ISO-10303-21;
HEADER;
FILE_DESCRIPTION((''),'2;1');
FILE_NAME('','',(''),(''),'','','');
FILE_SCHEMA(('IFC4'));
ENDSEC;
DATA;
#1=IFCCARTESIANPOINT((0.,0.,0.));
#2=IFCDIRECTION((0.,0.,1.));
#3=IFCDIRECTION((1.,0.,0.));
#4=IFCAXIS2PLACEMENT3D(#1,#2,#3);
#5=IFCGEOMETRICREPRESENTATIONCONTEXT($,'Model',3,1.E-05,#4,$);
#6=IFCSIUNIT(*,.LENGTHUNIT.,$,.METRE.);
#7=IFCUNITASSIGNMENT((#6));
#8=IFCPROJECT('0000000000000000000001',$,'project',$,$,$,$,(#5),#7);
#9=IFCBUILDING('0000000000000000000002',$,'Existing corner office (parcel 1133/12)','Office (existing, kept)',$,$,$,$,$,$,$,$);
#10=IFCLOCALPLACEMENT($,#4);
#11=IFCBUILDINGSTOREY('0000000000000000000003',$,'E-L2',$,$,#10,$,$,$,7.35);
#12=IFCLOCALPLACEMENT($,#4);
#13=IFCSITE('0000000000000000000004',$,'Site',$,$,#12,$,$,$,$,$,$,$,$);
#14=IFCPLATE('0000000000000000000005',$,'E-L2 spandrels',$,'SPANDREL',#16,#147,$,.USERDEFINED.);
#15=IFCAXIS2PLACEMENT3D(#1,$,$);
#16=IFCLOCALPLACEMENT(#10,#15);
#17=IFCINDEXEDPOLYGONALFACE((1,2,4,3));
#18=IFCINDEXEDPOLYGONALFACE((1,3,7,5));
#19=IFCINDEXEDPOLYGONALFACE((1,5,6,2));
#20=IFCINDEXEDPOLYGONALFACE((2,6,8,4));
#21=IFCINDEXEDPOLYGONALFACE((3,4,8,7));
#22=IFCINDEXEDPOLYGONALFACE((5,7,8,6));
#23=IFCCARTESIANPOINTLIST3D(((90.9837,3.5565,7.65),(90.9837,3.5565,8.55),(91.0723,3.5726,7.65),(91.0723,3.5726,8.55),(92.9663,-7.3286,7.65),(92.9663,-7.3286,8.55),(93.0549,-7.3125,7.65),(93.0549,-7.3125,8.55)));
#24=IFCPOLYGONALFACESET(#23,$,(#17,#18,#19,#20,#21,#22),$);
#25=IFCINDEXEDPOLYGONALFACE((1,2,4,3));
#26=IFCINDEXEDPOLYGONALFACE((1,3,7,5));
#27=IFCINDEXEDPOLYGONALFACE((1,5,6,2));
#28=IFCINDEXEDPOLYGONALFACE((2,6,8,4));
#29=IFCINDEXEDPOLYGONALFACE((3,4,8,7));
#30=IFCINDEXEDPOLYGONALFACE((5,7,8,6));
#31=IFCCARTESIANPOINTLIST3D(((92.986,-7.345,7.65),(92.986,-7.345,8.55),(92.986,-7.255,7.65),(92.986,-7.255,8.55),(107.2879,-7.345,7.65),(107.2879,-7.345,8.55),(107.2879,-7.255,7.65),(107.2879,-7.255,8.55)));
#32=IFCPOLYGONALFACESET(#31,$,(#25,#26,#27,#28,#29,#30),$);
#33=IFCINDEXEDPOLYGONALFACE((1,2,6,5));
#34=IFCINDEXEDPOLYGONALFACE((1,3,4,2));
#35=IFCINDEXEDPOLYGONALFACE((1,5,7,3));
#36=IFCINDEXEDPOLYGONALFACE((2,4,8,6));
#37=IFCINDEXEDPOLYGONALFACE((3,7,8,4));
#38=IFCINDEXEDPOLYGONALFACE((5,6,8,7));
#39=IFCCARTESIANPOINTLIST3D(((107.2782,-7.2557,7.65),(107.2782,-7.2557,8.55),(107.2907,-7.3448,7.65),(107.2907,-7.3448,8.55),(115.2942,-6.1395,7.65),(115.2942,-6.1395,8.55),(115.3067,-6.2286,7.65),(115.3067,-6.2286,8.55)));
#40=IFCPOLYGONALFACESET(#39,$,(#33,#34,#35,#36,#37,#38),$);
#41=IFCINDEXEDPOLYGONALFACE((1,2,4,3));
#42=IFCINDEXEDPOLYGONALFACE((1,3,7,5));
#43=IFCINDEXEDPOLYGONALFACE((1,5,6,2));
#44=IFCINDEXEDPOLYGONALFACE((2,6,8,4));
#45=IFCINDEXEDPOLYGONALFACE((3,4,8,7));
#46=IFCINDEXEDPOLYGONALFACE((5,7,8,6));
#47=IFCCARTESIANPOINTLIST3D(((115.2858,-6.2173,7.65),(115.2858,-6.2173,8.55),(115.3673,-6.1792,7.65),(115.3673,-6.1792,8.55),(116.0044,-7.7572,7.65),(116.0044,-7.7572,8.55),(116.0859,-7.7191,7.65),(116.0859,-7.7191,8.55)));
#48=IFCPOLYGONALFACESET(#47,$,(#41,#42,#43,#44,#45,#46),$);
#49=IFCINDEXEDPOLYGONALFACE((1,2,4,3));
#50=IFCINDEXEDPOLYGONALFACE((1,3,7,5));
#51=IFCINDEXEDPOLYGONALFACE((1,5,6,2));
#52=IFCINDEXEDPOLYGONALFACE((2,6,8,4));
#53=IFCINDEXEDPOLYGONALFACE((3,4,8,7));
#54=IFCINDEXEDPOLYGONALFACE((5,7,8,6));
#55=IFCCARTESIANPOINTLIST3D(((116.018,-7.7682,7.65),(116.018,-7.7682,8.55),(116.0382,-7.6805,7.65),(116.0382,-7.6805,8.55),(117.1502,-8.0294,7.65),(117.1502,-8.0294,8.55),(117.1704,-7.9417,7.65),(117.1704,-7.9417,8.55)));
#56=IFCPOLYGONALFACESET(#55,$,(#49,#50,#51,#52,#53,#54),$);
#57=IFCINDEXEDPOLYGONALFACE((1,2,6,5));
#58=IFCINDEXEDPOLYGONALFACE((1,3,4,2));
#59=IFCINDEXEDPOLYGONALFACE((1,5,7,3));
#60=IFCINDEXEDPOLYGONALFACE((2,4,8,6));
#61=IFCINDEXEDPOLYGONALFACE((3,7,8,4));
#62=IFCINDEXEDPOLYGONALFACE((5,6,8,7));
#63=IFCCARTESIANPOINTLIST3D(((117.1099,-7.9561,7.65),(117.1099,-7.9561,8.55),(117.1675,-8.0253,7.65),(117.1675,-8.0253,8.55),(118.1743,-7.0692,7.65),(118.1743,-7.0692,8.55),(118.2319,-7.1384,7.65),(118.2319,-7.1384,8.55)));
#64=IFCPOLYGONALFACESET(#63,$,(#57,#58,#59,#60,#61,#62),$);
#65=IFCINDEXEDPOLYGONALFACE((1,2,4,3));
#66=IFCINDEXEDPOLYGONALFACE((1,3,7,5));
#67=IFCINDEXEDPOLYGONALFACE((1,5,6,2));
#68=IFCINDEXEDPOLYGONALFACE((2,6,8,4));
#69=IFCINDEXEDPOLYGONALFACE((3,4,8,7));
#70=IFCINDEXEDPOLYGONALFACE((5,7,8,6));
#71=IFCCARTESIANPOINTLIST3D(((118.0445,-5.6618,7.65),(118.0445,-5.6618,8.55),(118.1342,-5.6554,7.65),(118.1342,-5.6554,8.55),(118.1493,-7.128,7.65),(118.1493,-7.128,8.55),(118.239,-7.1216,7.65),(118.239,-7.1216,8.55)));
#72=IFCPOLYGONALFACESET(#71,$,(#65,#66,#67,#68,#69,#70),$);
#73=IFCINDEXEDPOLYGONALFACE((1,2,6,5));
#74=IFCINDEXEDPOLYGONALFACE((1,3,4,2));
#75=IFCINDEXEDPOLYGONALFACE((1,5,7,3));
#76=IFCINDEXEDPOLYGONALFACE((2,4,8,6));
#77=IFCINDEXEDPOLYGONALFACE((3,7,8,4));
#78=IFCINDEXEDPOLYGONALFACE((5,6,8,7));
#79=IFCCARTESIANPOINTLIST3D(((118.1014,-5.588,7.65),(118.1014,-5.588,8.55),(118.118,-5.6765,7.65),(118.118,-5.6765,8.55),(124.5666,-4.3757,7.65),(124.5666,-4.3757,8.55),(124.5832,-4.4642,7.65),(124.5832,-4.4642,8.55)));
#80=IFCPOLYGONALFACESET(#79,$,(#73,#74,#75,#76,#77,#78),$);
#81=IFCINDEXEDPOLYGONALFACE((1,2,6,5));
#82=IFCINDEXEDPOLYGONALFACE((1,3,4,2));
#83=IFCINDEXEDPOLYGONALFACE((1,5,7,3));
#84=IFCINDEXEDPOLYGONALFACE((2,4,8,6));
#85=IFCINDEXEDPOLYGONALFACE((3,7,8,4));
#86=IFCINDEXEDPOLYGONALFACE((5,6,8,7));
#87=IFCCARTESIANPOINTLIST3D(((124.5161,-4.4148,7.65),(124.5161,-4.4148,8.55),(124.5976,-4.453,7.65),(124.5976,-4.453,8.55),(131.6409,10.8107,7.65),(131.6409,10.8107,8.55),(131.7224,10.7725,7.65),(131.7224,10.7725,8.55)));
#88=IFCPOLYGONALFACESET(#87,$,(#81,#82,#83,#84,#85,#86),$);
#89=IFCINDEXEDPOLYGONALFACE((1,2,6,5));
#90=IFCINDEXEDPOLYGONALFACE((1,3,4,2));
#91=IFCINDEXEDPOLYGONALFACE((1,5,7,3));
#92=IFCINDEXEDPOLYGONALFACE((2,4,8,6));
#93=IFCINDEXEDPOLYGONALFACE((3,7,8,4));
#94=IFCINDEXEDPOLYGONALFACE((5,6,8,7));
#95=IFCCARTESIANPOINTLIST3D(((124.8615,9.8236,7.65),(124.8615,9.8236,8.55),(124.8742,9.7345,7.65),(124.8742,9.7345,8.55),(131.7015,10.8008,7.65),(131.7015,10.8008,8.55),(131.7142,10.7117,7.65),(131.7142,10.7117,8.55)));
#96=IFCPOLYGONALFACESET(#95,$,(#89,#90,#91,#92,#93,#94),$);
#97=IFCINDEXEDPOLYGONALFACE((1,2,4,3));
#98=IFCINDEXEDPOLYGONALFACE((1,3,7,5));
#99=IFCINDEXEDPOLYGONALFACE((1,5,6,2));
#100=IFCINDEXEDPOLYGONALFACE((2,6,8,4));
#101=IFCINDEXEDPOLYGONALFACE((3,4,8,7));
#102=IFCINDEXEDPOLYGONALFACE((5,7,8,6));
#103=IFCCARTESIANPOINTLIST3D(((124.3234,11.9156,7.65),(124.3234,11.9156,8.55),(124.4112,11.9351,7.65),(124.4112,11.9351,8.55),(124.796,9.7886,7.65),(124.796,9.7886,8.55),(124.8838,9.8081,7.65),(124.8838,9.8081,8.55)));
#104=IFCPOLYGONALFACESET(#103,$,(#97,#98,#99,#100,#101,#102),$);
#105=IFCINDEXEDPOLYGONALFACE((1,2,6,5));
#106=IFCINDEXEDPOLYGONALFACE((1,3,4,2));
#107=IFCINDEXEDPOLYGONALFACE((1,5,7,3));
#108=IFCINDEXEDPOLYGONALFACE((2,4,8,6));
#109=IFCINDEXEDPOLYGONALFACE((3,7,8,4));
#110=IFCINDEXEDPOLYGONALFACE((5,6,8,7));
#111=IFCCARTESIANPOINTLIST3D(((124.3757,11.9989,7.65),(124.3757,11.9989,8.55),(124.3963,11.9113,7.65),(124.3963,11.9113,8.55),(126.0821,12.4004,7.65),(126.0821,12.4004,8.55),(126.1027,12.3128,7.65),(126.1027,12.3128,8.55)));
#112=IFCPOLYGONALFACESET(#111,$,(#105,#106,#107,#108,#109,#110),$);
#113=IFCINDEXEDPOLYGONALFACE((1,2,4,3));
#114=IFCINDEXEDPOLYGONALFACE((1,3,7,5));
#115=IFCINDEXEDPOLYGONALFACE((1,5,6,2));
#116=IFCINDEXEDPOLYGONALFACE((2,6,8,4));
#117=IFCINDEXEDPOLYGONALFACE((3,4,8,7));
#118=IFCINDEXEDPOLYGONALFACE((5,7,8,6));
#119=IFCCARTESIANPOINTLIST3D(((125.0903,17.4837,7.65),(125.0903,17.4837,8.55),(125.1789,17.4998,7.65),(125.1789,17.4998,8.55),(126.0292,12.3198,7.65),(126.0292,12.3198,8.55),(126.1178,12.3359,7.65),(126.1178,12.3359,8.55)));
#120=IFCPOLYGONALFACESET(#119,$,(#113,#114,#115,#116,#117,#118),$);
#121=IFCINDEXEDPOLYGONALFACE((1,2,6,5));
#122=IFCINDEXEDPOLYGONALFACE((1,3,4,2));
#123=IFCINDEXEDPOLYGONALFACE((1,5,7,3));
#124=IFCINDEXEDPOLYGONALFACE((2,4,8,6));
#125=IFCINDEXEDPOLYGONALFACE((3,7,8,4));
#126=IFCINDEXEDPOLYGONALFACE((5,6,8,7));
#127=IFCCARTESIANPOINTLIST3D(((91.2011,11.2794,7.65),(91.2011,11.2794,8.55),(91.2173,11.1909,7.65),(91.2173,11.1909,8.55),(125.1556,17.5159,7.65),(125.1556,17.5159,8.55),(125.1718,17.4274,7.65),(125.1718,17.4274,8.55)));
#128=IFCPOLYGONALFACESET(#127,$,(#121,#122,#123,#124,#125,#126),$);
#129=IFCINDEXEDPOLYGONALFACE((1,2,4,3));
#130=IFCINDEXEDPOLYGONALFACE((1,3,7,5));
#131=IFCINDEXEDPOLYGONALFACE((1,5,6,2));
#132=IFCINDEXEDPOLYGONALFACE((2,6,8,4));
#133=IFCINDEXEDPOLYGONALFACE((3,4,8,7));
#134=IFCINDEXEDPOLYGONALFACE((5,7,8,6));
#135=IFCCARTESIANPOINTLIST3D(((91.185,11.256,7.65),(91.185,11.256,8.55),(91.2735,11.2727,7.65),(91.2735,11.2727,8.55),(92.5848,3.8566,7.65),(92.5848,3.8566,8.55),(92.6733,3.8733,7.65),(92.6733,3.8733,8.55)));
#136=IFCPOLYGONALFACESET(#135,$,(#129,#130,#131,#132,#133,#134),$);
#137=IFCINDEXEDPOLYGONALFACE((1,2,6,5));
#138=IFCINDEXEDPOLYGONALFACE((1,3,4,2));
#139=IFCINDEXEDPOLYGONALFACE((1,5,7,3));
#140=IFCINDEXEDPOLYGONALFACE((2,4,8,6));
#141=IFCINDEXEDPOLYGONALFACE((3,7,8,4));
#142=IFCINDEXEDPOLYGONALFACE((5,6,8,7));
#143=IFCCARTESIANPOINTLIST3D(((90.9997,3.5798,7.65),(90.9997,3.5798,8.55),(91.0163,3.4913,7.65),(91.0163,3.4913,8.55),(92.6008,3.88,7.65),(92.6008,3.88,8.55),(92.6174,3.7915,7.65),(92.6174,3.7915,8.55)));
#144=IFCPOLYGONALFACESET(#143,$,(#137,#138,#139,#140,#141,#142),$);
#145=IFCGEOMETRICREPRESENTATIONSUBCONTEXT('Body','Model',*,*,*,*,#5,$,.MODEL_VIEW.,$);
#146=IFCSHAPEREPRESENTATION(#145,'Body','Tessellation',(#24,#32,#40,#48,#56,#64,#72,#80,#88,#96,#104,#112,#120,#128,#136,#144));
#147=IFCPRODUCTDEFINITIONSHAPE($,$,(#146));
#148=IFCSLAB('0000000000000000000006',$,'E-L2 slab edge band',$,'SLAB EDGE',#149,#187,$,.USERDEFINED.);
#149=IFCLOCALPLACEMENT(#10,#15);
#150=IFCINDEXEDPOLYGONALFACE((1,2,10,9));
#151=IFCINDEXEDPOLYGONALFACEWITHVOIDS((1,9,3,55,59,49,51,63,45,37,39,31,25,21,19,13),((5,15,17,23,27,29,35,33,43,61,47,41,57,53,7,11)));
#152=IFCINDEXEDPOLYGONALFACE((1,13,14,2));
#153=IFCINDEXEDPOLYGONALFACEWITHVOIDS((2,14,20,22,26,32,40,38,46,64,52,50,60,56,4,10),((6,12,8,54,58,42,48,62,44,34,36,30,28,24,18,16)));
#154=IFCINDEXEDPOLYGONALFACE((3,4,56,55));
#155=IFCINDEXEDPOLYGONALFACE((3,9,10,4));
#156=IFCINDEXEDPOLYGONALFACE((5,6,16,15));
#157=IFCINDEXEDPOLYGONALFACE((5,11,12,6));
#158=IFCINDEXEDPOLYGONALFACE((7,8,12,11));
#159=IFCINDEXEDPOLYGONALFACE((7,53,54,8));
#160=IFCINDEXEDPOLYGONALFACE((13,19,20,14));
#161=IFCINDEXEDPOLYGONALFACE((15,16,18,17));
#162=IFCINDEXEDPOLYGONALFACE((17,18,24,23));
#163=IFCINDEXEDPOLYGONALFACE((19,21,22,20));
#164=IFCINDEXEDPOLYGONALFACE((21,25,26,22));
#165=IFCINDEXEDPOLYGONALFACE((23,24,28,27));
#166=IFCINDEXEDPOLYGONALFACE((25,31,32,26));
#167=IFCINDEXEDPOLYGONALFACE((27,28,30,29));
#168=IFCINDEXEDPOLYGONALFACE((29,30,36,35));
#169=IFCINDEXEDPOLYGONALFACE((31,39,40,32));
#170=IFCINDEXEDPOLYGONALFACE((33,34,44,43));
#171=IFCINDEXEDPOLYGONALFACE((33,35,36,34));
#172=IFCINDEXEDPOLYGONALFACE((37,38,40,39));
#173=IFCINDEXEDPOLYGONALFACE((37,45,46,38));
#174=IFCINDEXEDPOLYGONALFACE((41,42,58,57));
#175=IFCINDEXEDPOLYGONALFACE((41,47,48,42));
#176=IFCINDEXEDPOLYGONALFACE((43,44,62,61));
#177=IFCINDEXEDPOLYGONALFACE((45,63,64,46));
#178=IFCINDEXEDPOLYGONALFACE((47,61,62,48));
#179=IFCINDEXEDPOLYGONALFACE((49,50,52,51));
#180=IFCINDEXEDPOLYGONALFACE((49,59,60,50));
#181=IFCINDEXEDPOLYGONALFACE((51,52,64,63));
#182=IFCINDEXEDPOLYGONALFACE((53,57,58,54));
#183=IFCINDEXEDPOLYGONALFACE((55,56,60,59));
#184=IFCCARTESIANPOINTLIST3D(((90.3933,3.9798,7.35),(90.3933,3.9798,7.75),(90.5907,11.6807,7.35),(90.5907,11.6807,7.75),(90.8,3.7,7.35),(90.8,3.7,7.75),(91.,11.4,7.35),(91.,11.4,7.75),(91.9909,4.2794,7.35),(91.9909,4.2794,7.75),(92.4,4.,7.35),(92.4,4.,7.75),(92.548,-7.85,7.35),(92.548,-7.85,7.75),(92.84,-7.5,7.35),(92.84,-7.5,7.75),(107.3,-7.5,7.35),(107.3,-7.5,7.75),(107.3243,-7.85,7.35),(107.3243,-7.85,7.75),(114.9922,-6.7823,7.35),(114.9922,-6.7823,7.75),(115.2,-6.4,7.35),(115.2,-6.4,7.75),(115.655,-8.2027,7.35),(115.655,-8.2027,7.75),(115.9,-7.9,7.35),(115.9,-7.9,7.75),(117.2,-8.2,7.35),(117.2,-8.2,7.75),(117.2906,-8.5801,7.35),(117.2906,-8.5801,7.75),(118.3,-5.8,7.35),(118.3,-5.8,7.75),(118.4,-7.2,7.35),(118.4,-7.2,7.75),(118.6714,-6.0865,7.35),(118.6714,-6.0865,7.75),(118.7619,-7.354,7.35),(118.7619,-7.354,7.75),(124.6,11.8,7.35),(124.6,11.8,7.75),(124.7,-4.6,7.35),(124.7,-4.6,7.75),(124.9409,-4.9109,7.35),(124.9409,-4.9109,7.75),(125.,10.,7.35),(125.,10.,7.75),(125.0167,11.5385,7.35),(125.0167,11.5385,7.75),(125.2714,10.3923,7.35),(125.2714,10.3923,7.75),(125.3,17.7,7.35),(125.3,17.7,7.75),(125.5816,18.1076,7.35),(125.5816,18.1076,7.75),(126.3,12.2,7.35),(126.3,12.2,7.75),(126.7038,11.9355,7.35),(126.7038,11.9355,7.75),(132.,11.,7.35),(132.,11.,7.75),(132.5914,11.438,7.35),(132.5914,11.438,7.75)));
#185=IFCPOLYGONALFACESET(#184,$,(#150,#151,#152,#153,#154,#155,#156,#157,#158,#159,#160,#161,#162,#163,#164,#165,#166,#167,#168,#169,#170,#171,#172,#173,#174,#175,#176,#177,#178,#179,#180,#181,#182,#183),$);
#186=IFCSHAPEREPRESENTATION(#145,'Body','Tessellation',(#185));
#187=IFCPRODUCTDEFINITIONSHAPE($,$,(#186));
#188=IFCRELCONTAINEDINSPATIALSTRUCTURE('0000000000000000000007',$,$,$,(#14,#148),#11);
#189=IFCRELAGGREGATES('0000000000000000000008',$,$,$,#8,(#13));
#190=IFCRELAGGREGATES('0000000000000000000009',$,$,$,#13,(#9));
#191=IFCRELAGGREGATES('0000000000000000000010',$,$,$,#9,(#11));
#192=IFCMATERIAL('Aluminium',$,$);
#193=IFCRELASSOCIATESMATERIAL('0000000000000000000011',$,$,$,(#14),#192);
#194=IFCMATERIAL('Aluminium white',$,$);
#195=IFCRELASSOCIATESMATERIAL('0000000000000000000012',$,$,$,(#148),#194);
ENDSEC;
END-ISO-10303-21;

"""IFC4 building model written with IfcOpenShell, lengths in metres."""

from ifc_helpers import new_model, si_unit, frame, origin_with_axes, place, context, subcontext, project, spatial, polyline, outline, extrude, material, element, save


model = new_model("IFC4")

# Units and contexts
model_context = context("Model", 3, precision=1e-05, world=origin_with_axes())
body_context = subcontext(model_context, "Body", "Model", "MODEL_VIEW")
ifc_project = project(units=[si_unit("LENGTHUNIT", "METRE")], contexts=[model_context])

# Site, building, storey
site_placement = place(None, origin_with_axes())
site = spatial("IfcSite", under=ifc_project, at=site_placement, Name="Site")
building = spatial("IfcBuilding", under=site, Name="Existing corner office (parcel 1133/12)", Description="Office (existing, kept)")
storey_placement = place(None, origin_with_axes())
storey = spatial("IfcBuildingStorey", under=building, at=storey_placement, Name="E-L2", Elevation=7.35)

# Shared definitions
ifc_material_1 = material(Name="Aluminium")
ifc_material_2 = material(Name="Aluminium white")

# Plate
plate_placement = place(storey_placement, origin_with_axes())
element("IfcPlate", 1, at=plate_placement, inside=storey, material=ifc_material_1, Name="E-L2 spandrels", ObjectType="SPANDREL", PredefinedType="USERDEFINED", context=body_context, shape_type="SweptSolid", body=[
    extrude(outline(polyline([(90.9837, 3.5565), (92.9663, -7.3286), (93.0549, -7.3125), (91.0723, 3.5726), (90.9837, 3.5565)])), frame((0.0, 0.0, 7.65), z_axis=(0.0, 0.0, 1.0), x_axis=(1.0, 0.0, 0.0)), (0.0, 0.0, 1.0), 0.9),
    extrude(outline(polyline([(92.986, -7.345), (107.2879, -7.345), (107.2879, -7.255), (92.986, -7.255), (92.986, -7.345)])), frame((0.0, 0.0, 7.65), z_axis=(0.0, 0.0, 1.0), x_axis=(1.0, 0.0, 0.0)), (0.0, 0.0, 1.0), 0.9),
    extrude(outline(polyline([(107.2907, -7.3448), (115.3067, -6.2286), (115.2942, -6.1395), (107.2782, -7.2557), (107.2907, -7.3448)])), frame((0.0, 0.0, 7.65), z_axis=(0.0, 0.0, 1.0), x_axis=(1.0, 0.0, 0.0)), (0.0, 0.0, 1.0), 0.9),
    extrude(outline(polyline([(115.2858, -6.2173), (116.0044, -7.7572), (116.0859, -7.7191), (115.3673, -6.1792), (115.2858, -6.2173)])), frame((0.0, 0.0, 7.65), z_axis=(0.0, 0.0, 1.0), x_axis=(1.0, 0.0, 0.0)), (0.0, 0.0, 1.0), 0.9),
    extrude(outline(polyline([(116.018, -7.7682), (117.1502, -8.0294), (117.1704, -7.9417), (116.0382, -7.6805), (116.018, -7.7682)])), frame((0.0, 0.0, 7.65), z_axis=(0.0, 0.0, 1.0), x_axis=(1.0, 0.0, 0.0)), (0.0, 0.0, 1.0), 0.9),
    extrude(outline(polyline([(117.1675, -8.0253), (118.2319, -7.1384), (118.1743, -7.0692), (117.1099, -7.9561), (117.1675, -8.0253)])), frame((0.0, 0.0, 7.65), z_axis=(0.0, 0.0, 1.0), x_axis=(1.0, 0.0, 0.0)), (0.0, 0.0, 1.0), 0.9),
    extrude(outline(polyline([(118.239, -7.1216), (118.1342, -5.6554), (118.0445, -5.6618), (118.1493, -7.128), (118.239, -7.1216)])), frame((0.0, 0.0, 7.65), z_axis=(0.0, 0.0, 1.0), x_axis=(1.0, 0.0, 0.0)), (0.0, 0.0, 1.0), 0.9),
    extrude(outline(polyline([(118.118, -5.6765), (124.5832, -4.4642), (124.5666, -4.3757), (118.1014, -5.588), (118.118, -5.6765)])), frame((0.0, 0.0, 7.65), z_axis=(0.0, 0.0, 1.0), x_axis=(1.0, 0.0, 0.0)), (0.0, 0.0, 1.0), 0.9),
    extrude(outline(polyline([(124.5976, -4.453), (131.7224, 10.7725), (131.6409, 10.8107), (124.5161, -4.4148), (124.5976, -4.453)])), frame((0.0, 0.0, 7.65), z_axis=(0.0, 0.0, 1.0), x_axis=(1.0, 0.0, 0.0)), (0.0, 0.0, 1.0), 0.9),
    extrude(outline(polyline([(131.7015, 10.8008), (124.8615, 9.8236), (124.8742, 9.7345), (131.7142, 10.7117), (131.7015, 10.8008)])), frame((0.0, 0.0, 7.65), z_axis=(0.0, 0.0, 1.0), x_axis=(1.0, 0.0, 0.0)), (0.0, 0.0, 1.0), 0.9),
    extrude(outline(polyline([(124.8838, 9.8081), (124.4112, 11.9351), (124.3234, 11.9156), (124.796, 9.7886), (124.8838, 9.8081)])), frame((0.0, 0.0, 7.65), z_axis=(0.0, 0.0, 1.0), x_axis=(1.0, 0.0, 0.0)), (0.0, 0.0, 1.0), 0.9),
    extrude(outline(polyline([(124.3963, 11.9113), (126.1027, 12.3128), (126.0821, 12.4004), (124.3757, 11.9989), (124.3963, 11.9113)])), frame((0.0, 0.0, 7.65), z_axis=(0.0, 0.0, 1.0), x_axis=(1.0, 0.0, 0.0)), (0.0, 0.0, 1.0), 0.9),
    extrude(outline(polyline([(126.1178, 12.3359), (125.1789, 17.4998), (125.0903, 17.4837), (126.0292, 12.3198), (126.1178, 12.3359)])), frame((0.0, 0.0, 7.65), z_axis=(0.0, 0.0, 1.0), x_axis=(1.0, 0.0, 0.0)), (0.0, 0.0, 1.0), 0.9),
    extrude(outline(polyline([(125.1556, 17.5159), (91.2011, 11.2794), (91.2173, 11.1909), (125.1718, 17.4274), (125.1556, 17.5159)])), frame((0.0, 0.0, 7.65), z_axis=(0.0, 0.0, 1.0), x_axis=(1.0, 0.0, 0.0)), (0.0, 0.0, 1.0), 0.9),
    extrude(outline(polyline([(91.185, 11.256), (92.5848, 3.8566), (92.6733, 3.8733), (91.2735, 11.2727), (91.185, 11.256)])), frame((0.0, 0.0, 7.65), z_axis=(0.0, 0.0, 1.0), x_axis=(1.0, 0.0, 0.0)), (0.0, 0.0, 1.0), 0.9),
    extrude(outline(polyline([(92.6008, 3.88), (90.9997, 3.5798), (91.0163, 3.4913), (92.6174, 3.7915), (92.6008, 3.88)])), frame((0.0, 0.0, 7.65), z_axis=(0.0, 0.0, 1.0), x_axis=(1.0, 0.0, 0.0)), (0.0, 0.0, 1.0), 0.9),
])

# Slab
slab_1_placement = place(storey_placement, origin_with_axes())
element("IfcSlab", 2, at=slab_1_placement, inside=storey, material=ifc_material_2, Name="E-L2 slab edge band", ObjectType="SLAB EDGE", PredefinedType="USERDEFINED", context=body_context, shape_type="SweptSolid", body=[
    extrude(outline(polyline([(90.3933, 3.9798), (92.548, -7.85), (107.3243, -7.85), (114.9922, -6.7823), (115.655, -8.2027), (117.2906, -8.5801), (118.7619, -7.354), (118.6714, -6.0865), (124.9409, -4.9109), (132.5914, 11.438), (125.2714, 10.3923), (125.0167, 11.5385), (126.7038, 11.9355), (125.5816, 18.1076), (90.5907, 11.6807), (91.9909, 4.2794), (90.3933, 3.9798)]), holes=[polyline([(90.8, 3.7), (92.84, -7.5), (107.3, -7.5), (115.2, -6.4), (115.9, -7.9), (117.2, -8.2), (118.4, -7.2), (118.3, -5.8), (124.7, -4.6), (132.0, 11.0), (125.0, 10.0), (124.6, 11.8), (126.3, 12.2), (125.3, 17.7), (91.0, 11.4), (92.4, 4.0), (90.8, 3.7)])]), frame((0.0, 0.0, 7.35), z_axis=(0.0, 0.0, 1.0), x_axis=(1.0, 0.0, 0.0)), (0.0, 0.0, 1.0), 0.4),
])

save(model, "model.ifc")
